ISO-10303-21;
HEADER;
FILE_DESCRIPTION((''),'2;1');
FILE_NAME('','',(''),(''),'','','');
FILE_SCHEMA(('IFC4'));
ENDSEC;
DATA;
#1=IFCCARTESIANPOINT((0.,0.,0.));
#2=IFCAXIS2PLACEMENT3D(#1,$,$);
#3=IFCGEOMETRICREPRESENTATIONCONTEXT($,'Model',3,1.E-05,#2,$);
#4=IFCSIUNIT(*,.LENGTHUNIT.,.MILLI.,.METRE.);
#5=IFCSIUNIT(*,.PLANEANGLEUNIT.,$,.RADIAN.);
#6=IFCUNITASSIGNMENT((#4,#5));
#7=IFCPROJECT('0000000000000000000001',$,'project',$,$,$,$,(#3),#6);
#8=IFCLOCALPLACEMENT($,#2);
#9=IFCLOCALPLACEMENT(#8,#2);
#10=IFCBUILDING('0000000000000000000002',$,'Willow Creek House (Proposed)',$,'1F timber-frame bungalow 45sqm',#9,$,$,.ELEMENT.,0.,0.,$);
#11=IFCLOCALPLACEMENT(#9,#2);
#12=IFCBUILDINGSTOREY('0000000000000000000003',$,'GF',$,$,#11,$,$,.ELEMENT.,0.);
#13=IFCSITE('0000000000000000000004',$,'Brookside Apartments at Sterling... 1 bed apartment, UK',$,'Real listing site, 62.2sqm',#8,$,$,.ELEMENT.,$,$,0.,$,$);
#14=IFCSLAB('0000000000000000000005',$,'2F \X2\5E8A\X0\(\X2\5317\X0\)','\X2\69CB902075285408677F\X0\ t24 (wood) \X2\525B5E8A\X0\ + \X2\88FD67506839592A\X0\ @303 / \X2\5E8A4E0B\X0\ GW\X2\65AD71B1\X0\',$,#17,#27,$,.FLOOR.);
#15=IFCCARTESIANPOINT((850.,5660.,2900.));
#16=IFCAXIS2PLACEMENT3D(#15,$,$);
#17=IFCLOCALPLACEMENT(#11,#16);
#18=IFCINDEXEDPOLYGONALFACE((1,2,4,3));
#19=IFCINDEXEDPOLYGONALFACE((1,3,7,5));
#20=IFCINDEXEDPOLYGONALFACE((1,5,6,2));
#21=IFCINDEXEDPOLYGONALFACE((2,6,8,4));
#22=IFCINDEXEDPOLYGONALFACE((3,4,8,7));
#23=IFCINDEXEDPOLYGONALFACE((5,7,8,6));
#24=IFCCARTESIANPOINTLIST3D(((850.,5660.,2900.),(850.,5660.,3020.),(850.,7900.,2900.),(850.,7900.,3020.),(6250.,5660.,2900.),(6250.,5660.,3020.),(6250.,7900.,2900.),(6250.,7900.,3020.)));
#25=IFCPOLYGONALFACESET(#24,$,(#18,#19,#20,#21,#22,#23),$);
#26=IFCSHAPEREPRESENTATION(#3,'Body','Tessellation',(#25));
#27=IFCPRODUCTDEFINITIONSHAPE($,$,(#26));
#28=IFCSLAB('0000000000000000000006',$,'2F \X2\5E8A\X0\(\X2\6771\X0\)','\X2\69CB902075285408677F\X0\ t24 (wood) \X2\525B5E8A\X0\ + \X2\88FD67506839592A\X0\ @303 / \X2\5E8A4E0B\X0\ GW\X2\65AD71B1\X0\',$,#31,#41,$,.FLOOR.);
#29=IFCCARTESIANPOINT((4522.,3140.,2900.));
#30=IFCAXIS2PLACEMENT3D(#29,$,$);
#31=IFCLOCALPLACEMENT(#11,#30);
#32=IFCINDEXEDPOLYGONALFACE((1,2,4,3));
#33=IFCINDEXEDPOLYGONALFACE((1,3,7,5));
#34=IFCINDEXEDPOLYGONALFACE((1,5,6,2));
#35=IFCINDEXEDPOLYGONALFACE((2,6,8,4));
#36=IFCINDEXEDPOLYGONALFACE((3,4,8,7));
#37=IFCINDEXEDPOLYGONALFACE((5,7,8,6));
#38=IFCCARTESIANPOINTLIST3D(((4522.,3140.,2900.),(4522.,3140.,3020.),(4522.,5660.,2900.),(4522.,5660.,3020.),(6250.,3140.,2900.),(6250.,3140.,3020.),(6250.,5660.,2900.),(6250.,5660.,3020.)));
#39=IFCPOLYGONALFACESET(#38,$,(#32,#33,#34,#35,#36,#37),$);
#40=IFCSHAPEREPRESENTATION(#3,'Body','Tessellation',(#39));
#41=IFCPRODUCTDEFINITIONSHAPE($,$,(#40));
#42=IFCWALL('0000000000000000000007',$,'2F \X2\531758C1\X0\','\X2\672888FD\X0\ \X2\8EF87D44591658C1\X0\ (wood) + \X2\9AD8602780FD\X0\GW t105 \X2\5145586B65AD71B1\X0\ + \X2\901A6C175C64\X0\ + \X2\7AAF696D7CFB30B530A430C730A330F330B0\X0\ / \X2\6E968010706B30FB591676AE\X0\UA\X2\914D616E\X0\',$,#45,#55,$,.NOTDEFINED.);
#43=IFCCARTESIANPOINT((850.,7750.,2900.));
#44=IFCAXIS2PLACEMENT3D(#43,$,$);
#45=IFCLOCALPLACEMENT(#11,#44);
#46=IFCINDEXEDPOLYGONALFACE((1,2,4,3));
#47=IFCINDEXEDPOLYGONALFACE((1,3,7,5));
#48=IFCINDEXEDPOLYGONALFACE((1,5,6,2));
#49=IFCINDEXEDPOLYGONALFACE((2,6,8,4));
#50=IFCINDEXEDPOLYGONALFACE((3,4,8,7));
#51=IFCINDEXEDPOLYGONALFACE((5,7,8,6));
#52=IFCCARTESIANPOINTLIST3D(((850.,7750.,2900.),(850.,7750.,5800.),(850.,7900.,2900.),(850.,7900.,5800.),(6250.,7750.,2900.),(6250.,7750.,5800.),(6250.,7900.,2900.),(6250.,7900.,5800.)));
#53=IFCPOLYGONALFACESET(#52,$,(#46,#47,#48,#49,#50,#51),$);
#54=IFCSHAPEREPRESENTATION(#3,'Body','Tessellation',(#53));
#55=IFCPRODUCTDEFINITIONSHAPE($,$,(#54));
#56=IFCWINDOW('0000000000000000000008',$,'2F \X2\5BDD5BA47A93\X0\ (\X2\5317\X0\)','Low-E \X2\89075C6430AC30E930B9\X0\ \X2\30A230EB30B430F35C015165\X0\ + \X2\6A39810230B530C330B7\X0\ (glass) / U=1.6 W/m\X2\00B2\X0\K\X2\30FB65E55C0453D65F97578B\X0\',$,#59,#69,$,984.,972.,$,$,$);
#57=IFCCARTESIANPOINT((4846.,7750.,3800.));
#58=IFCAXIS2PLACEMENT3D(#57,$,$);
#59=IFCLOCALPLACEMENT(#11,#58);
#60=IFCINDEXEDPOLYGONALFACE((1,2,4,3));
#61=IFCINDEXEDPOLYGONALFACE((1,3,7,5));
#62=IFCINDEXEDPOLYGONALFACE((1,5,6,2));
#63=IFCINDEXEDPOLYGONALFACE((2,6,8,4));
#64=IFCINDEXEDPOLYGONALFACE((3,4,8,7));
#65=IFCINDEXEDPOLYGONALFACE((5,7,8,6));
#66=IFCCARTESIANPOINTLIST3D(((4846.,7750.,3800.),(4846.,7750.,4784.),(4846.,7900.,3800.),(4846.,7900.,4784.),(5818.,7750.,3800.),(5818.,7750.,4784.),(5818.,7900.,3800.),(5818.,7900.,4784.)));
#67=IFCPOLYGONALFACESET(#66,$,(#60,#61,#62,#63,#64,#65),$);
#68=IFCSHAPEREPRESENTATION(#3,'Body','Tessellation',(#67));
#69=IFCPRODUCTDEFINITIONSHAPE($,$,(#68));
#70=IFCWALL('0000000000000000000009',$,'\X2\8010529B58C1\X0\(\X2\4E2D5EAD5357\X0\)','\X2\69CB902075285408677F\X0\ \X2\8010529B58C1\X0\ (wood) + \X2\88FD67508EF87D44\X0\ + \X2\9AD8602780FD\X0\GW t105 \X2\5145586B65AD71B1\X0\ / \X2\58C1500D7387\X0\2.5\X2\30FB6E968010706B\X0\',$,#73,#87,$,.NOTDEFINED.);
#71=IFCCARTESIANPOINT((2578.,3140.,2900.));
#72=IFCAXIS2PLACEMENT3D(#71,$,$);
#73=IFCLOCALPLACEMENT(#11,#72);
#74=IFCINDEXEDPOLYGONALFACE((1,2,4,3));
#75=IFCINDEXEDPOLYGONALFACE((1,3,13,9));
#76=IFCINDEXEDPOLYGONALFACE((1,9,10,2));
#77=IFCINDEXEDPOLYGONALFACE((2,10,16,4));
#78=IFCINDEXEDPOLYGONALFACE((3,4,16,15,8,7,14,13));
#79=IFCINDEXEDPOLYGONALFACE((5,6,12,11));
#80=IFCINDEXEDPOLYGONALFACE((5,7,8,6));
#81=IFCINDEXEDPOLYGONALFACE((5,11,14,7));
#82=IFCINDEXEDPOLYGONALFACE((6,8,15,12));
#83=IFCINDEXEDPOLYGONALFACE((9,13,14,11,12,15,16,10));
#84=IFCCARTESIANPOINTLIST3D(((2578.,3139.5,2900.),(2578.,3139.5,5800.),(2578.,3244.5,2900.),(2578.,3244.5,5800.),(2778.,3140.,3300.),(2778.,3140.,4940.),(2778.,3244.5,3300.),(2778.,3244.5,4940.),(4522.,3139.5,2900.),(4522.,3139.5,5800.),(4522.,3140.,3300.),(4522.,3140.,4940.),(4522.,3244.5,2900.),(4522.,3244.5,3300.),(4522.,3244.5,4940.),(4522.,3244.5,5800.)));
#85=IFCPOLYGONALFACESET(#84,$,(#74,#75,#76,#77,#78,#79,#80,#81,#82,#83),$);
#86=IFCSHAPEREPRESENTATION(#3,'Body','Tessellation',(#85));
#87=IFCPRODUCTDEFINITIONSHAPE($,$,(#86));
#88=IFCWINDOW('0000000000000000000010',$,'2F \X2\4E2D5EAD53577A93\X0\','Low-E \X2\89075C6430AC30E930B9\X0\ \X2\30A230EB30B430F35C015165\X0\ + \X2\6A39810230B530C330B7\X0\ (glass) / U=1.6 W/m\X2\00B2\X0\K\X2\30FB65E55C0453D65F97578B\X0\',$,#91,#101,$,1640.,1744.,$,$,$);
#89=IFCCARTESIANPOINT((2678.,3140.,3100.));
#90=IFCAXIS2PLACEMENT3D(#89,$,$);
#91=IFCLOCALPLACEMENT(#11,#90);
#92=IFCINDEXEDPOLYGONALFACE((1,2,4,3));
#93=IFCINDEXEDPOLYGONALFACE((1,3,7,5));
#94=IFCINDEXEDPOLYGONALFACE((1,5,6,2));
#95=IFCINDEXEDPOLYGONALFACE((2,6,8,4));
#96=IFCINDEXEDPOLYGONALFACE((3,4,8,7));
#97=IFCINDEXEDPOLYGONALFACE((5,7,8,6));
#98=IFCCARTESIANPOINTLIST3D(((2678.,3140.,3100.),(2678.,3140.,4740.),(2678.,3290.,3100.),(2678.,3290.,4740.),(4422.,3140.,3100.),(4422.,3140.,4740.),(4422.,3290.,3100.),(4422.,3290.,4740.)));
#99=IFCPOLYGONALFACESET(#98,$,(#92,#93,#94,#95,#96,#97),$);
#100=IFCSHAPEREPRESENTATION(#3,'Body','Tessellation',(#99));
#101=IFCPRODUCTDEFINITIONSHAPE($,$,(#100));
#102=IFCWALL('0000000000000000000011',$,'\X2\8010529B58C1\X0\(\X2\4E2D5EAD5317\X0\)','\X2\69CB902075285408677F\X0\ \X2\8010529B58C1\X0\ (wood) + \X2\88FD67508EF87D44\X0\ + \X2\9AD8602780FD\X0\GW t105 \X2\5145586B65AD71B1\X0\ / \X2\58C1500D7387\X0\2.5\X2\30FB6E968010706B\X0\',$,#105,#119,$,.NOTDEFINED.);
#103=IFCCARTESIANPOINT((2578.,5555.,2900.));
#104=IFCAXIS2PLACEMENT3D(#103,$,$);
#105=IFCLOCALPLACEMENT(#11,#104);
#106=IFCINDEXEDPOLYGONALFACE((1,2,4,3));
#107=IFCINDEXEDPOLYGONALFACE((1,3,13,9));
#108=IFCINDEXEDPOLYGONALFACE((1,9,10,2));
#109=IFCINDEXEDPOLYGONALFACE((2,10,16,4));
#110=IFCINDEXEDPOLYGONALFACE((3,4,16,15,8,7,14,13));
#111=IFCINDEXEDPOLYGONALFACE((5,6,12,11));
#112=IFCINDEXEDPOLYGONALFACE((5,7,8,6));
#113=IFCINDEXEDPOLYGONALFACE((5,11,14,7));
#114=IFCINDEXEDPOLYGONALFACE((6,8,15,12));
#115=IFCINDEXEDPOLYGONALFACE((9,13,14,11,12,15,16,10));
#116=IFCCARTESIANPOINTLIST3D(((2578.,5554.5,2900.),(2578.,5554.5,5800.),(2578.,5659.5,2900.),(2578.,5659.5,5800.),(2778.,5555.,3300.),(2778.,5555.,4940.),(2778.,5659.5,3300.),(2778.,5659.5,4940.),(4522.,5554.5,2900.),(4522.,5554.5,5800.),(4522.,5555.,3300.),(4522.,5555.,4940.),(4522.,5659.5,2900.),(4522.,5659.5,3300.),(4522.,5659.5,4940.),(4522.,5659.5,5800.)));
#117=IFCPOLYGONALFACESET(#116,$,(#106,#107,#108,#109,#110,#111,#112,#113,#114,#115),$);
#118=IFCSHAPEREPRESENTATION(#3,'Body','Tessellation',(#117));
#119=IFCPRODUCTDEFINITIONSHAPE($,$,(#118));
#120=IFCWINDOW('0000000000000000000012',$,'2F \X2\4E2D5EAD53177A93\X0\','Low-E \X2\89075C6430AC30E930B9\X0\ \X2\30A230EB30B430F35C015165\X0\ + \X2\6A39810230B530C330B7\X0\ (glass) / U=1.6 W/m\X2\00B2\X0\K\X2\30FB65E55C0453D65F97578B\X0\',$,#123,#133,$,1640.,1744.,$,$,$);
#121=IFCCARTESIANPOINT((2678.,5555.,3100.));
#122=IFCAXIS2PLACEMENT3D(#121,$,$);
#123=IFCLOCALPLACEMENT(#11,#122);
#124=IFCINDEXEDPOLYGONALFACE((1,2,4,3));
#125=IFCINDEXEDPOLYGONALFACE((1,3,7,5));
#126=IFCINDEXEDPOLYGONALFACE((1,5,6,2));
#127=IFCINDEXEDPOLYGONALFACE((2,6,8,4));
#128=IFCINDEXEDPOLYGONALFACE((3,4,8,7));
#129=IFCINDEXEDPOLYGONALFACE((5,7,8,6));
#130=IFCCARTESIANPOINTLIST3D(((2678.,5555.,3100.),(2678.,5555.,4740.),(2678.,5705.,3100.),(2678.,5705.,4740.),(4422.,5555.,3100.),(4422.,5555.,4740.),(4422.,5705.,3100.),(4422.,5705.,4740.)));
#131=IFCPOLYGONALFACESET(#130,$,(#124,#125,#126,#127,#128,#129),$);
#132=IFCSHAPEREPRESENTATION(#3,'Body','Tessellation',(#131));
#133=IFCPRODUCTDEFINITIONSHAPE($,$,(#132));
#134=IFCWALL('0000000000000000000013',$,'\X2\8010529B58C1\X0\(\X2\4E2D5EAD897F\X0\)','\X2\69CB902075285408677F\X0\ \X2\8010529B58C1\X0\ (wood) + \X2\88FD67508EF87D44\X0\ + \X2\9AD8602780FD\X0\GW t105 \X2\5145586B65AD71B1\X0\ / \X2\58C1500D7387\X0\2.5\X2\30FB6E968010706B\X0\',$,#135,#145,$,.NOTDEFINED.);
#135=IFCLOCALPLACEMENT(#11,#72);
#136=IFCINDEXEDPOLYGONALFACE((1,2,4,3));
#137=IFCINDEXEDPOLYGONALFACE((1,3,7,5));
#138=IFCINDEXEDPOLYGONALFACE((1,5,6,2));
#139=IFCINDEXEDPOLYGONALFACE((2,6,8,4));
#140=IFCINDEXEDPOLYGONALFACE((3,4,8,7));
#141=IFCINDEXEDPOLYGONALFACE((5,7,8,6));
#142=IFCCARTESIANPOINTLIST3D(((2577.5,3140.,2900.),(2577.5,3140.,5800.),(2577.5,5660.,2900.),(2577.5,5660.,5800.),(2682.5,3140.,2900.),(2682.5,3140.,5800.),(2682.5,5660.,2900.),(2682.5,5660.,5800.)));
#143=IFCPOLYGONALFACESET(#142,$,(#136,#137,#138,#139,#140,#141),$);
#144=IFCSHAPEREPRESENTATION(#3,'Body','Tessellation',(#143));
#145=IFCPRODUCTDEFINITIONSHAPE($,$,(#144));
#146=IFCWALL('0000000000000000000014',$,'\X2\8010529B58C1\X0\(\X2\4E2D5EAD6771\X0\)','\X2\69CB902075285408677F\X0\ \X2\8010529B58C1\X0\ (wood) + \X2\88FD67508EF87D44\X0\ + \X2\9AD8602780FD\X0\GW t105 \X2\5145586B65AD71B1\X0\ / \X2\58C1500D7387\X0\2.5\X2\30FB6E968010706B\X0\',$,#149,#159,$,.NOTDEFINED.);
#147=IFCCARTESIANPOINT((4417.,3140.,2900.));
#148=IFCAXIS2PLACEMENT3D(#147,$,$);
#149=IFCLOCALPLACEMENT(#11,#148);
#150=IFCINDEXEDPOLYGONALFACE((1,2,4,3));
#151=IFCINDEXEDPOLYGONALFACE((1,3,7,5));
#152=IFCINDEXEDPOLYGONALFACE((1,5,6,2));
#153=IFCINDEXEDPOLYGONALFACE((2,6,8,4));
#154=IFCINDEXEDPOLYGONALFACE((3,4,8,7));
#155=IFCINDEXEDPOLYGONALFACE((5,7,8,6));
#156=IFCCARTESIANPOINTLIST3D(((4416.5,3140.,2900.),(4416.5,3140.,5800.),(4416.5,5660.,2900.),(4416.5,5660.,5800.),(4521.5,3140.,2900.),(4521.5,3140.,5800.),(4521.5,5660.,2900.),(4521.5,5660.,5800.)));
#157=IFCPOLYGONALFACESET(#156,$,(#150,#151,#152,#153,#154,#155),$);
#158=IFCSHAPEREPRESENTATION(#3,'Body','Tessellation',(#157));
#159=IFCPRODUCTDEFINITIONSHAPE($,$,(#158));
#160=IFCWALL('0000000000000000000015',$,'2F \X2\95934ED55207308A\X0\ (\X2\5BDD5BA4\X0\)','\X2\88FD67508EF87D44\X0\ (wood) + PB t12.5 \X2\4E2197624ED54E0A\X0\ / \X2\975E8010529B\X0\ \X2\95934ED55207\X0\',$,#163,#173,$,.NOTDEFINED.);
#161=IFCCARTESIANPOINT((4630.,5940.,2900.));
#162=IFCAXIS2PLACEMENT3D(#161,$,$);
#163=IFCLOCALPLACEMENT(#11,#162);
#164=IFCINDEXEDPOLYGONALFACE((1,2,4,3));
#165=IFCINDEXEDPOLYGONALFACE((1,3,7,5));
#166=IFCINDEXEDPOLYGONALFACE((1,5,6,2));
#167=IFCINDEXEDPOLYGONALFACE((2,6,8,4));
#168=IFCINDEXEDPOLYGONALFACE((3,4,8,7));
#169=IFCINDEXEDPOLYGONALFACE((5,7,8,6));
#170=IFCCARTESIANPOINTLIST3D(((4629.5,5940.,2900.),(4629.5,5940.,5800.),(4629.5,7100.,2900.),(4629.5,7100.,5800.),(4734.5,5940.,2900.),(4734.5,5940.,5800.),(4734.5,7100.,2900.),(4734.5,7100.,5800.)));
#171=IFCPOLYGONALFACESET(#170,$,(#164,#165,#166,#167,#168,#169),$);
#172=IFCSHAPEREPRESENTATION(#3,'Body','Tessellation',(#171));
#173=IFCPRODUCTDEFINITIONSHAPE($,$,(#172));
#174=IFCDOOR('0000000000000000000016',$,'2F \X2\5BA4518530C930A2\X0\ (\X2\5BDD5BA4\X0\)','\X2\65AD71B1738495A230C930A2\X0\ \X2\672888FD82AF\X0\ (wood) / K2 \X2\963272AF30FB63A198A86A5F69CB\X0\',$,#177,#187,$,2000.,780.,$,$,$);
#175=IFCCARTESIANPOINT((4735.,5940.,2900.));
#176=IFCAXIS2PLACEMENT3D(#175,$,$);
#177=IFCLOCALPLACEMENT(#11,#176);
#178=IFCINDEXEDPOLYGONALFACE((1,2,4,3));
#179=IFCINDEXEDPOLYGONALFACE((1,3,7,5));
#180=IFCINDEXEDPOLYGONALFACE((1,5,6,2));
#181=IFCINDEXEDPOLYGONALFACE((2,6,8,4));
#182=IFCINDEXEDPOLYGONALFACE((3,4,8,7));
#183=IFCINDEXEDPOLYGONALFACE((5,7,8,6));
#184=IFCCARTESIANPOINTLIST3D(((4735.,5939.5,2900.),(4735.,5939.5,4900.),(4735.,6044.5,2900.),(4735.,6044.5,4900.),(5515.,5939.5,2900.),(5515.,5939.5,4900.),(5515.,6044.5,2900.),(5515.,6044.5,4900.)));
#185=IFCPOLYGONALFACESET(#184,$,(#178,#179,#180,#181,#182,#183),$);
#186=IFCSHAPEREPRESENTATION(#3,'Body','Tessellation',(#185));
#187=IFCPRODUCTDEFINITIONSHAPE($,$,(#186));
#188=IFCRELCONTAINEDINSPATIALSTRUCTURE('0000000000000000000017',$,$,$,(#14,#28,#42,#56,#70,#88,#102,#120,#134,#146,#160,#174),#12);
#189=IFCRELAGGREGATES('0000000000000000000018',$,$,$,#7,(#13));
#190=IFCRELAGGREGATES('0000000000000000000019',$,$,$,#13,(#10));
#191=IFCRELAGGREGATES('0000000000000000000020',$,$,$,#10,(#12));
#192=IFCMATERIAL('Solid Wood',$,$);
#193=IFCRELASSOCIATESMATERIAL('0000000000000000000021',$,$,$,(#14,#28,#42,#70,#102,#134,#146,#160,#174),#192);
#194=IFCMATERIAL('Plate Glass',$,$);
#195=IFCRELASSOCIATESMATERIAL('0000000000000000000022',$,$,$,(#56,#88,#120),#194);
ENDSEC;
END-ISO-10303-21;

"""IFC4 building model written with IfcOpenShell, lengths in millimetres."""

from ifc_helpers import new_model, si_unit, frame, frame_2d, origin, place, context, project, spatial, rectangle, extrude, material, element, fill, save


model = new_model("IFC4")

# Units and contexts
model_context = context("Model", 3, precision=1e-05, world=origin())
ifc_project = project(units=[si_unit("LENGTHUNIT", "METRE", prefix="MILLI"), si_unit("PLANEANGLEUNIT", "RADIAN")], contexts=[model_context])

# Site, building, storey
site_placement = place(None, origin())
site = spatial("IfcSite", under=ifc_project, at=site_placement, Name="Brookside Apartments at Sterling... 1 bed apartment, UK", ObjectType="Real listing site, 62.2sqm", CompositionType="ELEMENT", RefElevation=0.0)
building_placement = place(site_placement, origin())
building = spatial("IfcBuilding", under=site, at=building_placement, Name="Willow Creek House (Proposed)", ObjectType="1F timber-frame bungalow 45sqm", CompositionType="ELEMENT", ElevationOfRefHeight=0.0, ElevationOfTerrain=0.0)
storey_placement = place(building_placement, origin())
storey = spatial("IfcBuildingStorey", under=building, at=storey_placement, Name="GF", CompositionType="ELEMENT", Elevation=0.0)

# Slabs
ifc_material_1 = material(Name="Solid Wood")
slab_1_placement = place(storey_placement, frame((850.0, 5660.0, 2900.0)))
element("IfcSlab", 1, at=slab_1_placement, inside=storey, material=ifc_material_1, Name="2F 床(北)", Description="構造用合板 t24 (wood) 剛床 + 製材根太 @303 / 床下 GW断熱", PredefinedType="FLOOR", context=model_context, shape_type="SweptSolid", body=[
    extrude(rectangle(XDim=5400.0, YDim=2240.0, at=frame_2d((2700.0, 1120.0))), frame((850.0, 5660.0, 2900.0)), (0.0, 0.0, 1.0), 120.0),
])
slab_2_placement = place(storey_placement, frame((4522.0, 3140.0, 2900.0)))
element("IfcSlab", 2, at=slab_2_placement, inside=storey, material=ifc_material_1, Name="2F 床(東)", Description="構造用合板 t24 (wood) 剛床 + 製材根太 @303 / 床下 GW断熱", PredefinedType="FLOOR", context=model_context, shape_type="SweptSolid", body=[
    extrude(rectangle(XDim=1728.0, YDim=2520.0, at=frame_2d((864.0, 1260.0))), frame((4522.0, 3140.0, 2900.0)), (0.0, 0.0, 1.0), 120.0),
])

# Walls, openings, windows
wall_1_placement = place(storey_placement, frame((850.0, 7750.0, 2900.0)))
wall_1 = element("IfcWall", 3, at=wall_1_placement, inside=storey, material=ifc_material_1, Name="2F 北壁", Description="木製 軸組外壁 (wood) + 高性能GW t105 充填断熱 + 通気層 + 窯業系サイディング / 準耐火・外皮UA配慮", PredefinedType="NOTDEFINED", context=model_context, shape_type="SweptSolid", body=[
    extrude(rectangle(XDim=5400.0, YDim=150.0, at=frame_2d((2700.0, 75.0))), frame((850.0, 7750.0, 2900.0)), (0.0, 0.0, 1.0), 2900.0),
])
opening_1_placement = place(storey_placement, frame((4846.0, 7750.0, 3800.0)))
opening_1 = element("IfcOpeningElement", 4, at=opening_1_placement, cuts=wall_1, PredefinedType="NOTDEFINED", context=model_context, shape_type="SweptSolid", body=[
    extrude(rectangle(XDim=972.0, YDim=150.0, at=frame_2d((486.0, 75.0))), frame((4846.0, 7750.0, 3800.0)), (0.0, 0.0, 1.0), 984.0),
])
ifc_material_2 = material(Name="Plate Glass")
window_1_placement = place(storey_placement, frame((4846.0, 7750.0, 3800.0)))
window_1 = element("IfcWindow", 5, at=window_1_placement, inside=storey, material=ifc_material_2, Name="2F 寝室窓 (北)", Description="Low-E 複層ガラス アルゴン封入 + 樹脂サッシ (glass) / U=1.6 W/m²K・日射取得型", OverallHeight=984.0, OverallWidth=972.0, context=model_context, shape_type="SweptSolid", body=[
    extrude(rectangle(XDim=972.0, YDim=150.0, at=frame_2d((486.0, 75.0))), frame((4846.0, 7750.0, 3800.0)), (0.0, 0.0, 1.0), 984.0),
])
fill(opening_1, window_1)
wall_2_placement = place(storey_placement, frame((2578.0, 3140.0, 2900.0)))
wall_2 = element("IfcWall", 6, at=wall_2_placement, inside=storey, material=ifc_material_1, Name="耐力壁(中庭南)", Description="構造用合板 耐力壁 (wood) + 製材軸組 + 高性能GW t105 充填断熱 / 壁倍率2.5・準耐火", PredefinedType="NOTDEFINED", context=model_context, shape_type="SweptSolid", body=[
    extrude(rectangle(XDim=1944.0, YDim=105.0, at=frame_2d((972.0, 52.0))), frame((2578.0, 3140.0, 2900.0)), (0.0, 0.0, 1.0), 2900.0),
])
opening_2_placement = place(storey_placement, frame((2678.0, 3140.0, 3100.0)))
opening_2 = element("IfcOpeningElement", 7, at=opening_2_placement, cuts=wall_2, PredefinedType="NOTDEFINED", context=model_context, shape_type="SweptSolid", body=[
    extrude(rectangle(XDim=1744.0, YDim=150.0, at=frame_2d((872.0, 75.0))), frame((2678.0, 3140.0, 3100.0)), (0.0, 0.0, 1.0), 1640.0),
])
window_2_placement = place(storey_placement, frame((2678.0, 3140.0, 3100.0)))
window_2 = element("IfcWindow", 8, at=window_2_placement, inside=storey, material=ifc_material_2, Name="2F 中庭南窓", Description="Low-E 複層ガラス アルゴン封入 + 樹脂サッシ (glass) / U=1.6 W/m²K・日射取得型", OverallHeight=1640.0, OverallWidth=1744.0, context=model_context, shape_type="SweptSolid", body=[
    extrude(rectangle(XDim=1744.0, YDim=150.0, at=frame_2d((872.0, 75.0))), frame((2678.0, 3140.0, 3100.0)), (0.0, 0.0, 1.0), 1640.0),
])
fill(opening_2, window_2)
wall_3_placement = place(storey_placement, frame((2578.0, 5555.0, 2900.0)))
wall_3 = element("IfcWall", 9, at=wall_3_placement, inside=storey, material=ifc_material_1, Name="耐力壁(中庭北)", Description="構造用合板 耐力壁 (wood) + 製材軸組 + 高性能GW t105 充填断熱 / 壁倍率2.5・準耐火", PredefinedType="NOTDEFINED", context=model_context, shape_type="SweptSolid", body=[
    extrude(rectangle(XDim=1944.0, YDim=105.0, at=frame_2d((972.0, 52.0))), frame((2578.0, 5555.0, 2900.0)), (0.0, 0.0, 1.0), 2900.0),
])
opening_3_placement = place(storey_placement, frame((2678.0, 5555.0, 3100.0)))
opening_3 = element("IfcOpeningElement", 10, at=opening_3_placement, cuts=wall_3, PredefinedType="NOTDEFINED", context=model_context, shape_type="SweptSolid", body=[
    extrude(rectangle(XDim=1744.0, YDim=150.0, at=frame_2d((872.0, 75.0))), frame((2678.0, 5555.0, 3100.0)), (0.0, 0.0, 1.0), 1640.0),
])
window_3_placement = place(storey_placement, frame((2678.0, 5555.0, 3100.0)))
window_3 = element("IfcWindow", 11, at=window_3_placement, inside=storey, material=ifc_material_2, Name="2F 中庭北窓", Description="Low-E 複層ガラス アルゴン封入 + 樹脂サッシ (glass) / U=1.6 W/m²K・日射取得型", OverallHeight=1640.0, OverallWidth=1744.0, context=model_context, shape_type="SweptSolid", body=[
    extrude(rectangle(XDim=1744.0, YDim=150.0, at=frame_2d((872.0, 75.0))), frame((2678.0, 5555.0, 3100.0)), (0.0, 0.0, 1.0), 1640.0),
])
fill(opening_3, window_3)

# Walls
wall_4_placement = place(storey_placement, frame((2578.0, 3140.0, 2900.0)))
element("IfcWall", 12, at=wall_4_placement, inside=storey, material=ifc_material_1, Name="耐力壁(中庭西)", Description="構造用合板 耐力壁 (wood) + 製材軸組 + 高性能GW t105 充填断熱 / 壁倍率2.5・準耐火", PredefinedType="NOTDEFINED", context=model_context, shape_type="SweptSolid", body=[
    extrude(rectangle(XDim=105.0, YDim=2520.0, at=frame_2d((52.0, 1260.0))), frame((2578.0, 3140.0, 2900.0)), (0.0, 0.0, 1.0), 2900.0),
])
wall_5_placement = place(storey_placement, frame((4417.0, 3140.0, 2900.0)))
element("IfcWall", 13, at=wall_5_placement, inside=storey, material=ifc_material_1, Name="耐力壁(中庭東)", Description="構造用合板 耐力壁 (wood) + 製材軸組 + 高性能GW t105 充填断熱 / 壁倍率2.5・準耐火", PredefinedType="NOTDEFINED", context=model_context, shape_type="SweptSolid", body=[
    extrude(rectangle(XDim=105.0, YDim=2520.0, at=frame_2d((52.0, 1260.0))), frame((4417.0, 3140.0, 2900.0)), (0.0, 0.0, 1.0), 2900.0),
])
wall_6_placement = place(storey_placement, frame((4630.0, 5940.0, 2900.0)))
element("IfcWall", 14, at=wall_6_placement, inside=storey, material=ifc_material_1, Name="2F 間仕切り (寝室)", Description="製材軸組 (wood) + PB t12.5 両面仕上 / 非耐力 間仕切", PredefinedType="NOTDEFINED", context=model_context, shape_type="SweptSolid", body=[
    extrude(rectangle(XDim=105.0, YDim=1160.0, at=frame_2d((52.0, 580.0))), frame((4630.0, 5940.0, 2900.0)), (0.0, 0.0, 1.0), 2900.0),
])

# Door
door_placement = place(storey_placement, frame((4735.0, 5940.0, 2900.0)))
element("IfcDoor", 15, at=door_placement, inside=storey, material=ifc_material_1, Name="2F 室内ドア (寝室)", Description="断熱玄関ドア 木製芯 (wood) / K2 防犯・採風機構", OverallHeight=2000.0, OverallWidth=780.0, context=model_context, shape_type="SweptSolid", body=[
    extrude(rectangle(XDim=780.0, YDim=105.0, at=frame_2d((390.0, 52.0))), frame((4735.0, 5940.0, 2900.0)), (0.0, 0.0, 1.0), 2000.0),
])

save(model, "model.ifc")
